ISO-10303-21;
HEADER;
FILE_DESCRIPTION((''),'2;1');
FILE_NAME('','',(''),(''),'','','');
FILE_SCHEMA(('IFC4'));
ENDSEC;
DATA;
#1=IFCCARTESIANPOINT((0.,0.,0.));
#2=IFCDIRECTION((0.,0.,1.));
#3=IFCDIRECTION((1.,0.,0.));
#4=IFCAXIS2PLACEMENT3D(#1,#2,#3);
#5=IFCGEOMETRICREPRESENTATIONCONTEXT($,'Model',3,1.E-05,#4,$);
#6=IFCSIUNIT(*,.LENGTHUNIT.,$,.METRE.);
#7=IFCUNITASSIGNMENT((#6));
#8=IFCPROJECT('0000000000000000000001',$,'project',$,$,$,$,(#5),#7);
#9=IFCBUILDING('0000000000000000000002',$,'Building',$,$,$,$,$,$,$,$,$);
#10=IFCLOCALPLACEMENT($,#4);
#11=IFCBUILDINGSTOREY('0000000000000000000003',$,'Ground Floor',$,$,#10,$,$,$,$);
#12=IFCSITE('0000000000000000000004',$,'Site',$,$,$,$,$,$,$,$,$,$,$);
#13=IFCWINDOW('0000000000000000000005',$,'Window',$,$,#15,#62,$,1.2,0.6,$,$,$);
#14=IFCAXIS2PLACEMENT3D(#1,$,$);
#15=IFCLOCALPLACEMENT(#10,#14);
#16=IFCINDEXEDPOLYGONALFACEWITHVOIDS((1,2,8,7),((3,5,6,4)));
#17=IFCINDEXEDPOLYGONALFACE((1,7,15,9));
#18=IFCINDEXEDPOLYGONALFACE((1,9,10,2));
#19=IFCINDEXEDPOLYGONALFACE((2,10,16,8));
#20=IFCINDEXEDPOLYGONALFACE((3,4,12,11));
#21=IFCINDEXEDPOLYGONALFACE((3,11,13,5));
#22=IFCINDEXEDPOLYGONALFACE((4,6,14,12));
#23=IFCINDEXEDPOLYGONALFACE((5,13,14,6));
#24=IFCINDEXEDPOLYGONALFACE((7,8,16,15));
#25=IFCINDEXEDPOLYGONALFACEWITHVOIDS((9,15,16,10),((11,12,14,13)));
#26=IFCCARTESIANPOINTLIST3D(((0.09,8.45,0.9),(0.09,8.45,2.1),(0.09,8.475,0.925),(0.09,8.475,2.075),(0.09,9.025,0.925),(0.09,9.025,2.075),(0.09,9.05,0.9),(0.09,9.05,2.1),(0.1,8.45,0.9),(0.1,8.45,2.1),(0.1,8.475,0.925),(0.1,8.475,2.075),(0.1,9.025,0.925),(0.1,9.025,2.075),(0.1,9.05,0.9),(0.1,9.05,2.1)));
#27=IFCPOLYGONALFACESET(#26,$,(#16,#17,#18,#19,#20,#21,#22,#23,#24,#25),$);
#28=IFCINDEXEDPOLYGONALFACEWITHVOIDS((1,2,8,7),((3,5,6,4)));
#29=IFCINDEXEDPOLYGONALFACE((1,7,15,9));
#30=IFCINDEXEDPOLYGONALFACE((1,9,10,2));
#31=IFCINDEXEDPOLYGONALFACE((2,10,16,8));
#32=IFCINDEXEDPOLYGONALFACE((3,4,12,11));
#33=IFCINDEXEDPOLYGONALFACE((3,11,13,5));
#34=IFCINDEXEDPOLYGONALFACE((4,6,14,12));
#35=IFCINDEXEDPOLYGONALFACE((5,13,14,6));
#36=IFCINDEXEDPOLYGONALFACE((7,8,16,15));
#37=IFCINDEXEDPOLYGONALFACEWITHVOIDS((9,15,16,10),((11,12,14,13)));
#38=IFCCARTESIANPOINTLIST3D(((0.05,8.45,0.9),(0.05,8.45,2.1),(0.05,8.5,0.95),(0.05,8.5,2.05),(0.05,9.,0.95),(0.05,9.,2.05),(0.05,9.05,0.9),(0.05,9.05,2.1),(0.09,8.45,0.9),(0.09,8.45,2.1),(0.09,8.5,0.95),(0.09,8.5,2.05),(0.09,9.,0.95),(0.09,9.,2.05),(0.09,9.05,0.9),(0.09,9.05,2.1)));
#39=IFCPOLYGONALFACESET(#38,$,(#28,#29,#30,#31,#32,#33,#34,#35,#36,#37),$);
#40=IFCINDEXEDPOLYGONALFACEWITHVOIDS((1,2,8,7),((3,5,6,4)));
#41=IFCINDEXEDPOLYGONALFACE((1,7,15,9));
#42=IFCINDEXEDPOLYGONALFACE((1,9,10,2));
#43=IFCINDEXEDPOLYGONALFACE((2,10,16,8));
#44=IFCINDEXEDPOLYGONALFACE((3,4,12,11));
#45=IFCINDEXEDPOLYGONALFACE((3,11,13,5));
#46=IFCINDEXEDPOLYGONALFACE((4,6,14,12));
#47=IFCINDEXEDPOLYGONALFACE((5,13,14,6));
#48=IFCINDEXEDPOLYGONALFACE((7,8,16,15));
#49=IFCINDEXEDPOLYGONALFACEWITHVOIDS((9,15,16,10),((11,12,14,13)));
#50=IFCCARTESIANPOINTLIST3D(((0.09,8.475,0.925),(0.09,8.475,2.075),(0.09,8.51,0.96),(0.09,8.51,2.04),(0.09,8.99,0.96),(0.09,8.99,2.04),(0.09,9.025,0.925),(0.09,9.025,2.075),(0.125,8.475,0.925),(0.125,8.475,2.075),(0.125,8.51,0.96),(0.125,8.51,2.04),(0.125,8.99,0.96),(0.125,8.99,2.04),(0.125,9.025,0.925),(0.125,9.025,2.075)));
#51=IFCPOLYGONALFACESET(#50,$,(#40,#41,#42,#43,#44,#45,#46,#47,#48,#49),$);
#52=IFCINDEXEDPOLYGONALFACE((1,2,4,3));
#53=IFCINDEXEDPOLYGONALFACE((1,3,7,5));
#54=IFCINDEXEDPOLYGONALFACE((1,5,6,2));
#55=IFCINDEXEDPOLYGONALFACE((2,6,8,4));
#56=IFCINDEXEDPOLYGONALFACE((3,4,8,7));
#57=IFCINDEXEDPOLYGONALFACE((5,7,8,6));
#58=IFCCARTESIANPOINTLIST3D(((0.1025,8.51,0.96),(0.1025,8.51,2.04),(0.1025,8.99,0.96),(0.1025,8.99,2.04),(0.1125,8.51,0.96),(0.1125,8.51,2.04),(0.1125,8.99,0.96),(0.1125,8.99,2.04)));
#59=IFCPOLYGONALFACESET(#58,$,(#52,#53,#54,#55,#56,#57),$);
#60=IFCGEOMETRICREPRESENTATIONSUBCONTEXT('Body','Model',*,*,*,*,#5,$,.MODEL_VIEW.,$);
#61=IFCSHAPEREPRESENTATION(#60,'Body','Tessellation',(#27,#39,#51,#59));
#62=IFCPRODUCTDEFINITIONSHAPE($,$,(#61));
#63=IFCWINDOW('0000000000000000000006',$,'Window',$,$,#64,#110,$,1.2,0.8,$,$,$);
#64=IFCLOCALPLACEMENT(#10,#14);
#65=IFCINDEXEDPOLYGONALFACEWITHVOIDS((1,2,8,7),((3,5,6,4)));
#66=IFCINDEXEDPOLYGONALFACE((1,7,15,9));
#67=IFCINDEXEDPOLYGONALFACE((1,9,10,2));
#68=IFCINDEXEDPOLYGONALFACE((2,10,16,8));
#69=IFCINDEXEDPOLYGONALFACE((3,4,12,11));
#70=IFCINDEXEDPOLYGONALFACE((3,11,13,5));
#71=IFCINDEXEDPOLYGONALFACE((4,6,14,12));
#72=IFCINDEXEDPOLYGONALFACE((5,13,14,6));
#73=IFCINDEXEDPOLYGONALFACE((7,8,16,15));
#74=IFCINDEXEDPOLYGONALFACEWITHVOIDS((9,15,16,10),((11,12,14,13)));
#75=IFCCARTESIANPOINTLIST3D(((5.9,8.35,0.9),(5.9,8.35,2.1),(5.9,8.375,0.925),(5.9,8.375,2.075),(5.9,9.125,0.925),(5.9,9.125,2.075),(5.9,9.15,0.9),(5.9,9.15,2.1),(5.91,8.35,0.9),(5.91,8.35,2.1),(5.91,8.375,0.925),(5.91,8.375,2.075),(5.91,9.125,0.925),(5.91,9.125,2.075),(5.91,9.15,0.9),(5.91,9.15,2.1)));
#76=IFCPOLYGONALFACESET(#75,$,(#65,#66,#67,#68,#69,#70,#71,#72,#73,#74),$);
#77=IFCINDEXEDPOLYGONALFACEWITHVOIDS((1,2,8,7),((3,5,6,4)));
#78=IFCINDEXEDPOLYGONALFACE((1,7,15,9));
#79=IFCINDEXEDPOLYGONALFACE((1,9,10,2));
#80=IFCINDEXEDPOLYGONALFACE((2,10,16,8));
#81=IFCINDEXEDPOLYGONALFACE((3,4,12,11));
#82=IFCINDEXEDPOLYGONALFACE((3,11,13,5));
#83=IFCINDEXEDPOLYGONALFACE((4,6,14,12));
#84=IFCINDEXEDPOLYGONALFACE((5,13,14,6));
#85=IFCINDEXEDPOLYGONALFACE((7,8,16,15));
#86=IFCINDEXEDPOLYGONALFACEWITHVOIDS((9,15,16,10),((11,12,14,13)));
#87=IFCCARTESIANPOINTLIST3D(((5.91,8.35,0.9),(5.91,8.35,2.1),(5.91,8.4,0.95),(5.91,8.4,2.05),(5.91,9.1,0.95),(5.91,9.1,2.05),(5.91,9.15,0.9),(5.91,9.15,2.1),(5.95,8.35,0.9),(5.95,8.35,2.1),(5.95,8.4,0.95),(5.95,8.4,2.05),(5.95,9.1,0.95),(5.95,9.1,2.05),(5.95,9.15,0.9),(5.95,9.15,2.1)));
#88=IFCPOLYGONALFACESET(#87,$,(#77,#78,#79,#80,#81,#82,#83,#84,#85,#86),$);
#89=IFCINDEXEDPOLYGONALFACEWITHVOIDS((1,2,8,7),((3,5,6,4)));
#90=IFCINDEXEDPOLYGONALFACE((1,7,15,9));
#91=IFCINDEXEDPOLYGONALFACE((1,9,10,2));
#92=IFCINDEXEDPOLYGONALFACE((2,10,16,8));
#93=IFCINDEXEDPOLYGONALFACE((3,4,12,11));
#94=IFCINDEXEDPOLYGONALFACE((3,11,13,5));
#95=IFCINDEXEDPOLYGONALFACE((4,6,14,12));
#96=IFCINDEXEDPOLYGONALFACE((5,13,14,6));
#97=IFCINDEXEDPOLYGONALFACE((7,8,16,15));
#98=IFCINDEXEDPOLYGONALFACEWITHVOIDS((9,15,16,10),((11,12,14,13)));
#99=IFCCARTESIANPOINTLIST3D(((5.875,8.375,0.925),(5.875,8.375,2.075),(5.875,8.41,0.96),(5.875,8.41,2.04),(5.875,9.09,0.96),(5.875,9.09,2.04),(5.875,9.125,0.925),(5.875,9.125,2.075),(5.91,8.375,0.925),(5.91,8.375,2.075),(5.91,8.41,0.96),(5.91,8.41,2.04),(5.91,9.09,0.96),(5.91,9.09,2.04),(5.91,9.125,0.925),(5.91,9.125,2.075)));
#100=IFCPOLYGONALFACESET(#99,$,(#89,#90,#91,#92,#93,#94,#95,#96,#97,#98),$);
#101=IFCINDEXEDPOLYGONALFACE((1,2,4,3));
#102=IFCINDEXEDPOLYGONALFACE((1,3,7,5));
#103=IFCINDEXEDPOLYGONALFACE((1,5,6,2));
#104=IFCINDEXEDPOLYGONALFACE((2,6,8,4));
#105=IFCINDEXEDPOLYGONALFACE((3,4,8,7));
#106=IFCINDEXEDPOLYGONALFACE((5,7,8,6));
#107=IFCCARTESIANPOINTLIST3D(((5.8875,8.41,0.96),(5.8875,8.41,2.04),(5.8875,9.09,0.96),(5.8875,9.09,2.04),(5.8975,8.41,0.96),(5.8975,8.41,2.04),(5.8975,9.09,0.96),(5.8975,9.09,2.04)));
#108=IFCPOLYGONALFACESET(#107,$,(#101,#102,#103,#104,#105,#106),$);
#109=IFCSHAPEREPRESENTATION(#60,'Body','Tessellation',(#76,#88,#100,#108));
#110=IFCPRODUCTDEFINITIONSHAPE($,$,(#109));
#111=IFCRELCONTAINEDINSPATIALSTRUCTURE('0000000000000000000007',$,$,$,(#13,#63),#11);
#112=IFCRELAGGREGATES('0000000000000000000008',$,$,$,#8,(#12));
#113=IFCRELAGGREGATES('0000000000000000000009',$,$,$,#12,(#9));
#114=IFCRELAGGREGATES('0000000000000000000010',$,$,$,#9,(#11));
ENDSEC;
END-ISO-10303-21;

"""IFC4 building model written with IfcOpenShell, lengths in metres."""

from ifc_helpers import new_model, si_unit, frame, origin_with_axes, place, context, subcontext, project, spatial, line, indexed_curve, outline, extrude, element, save


model = new_model("IFC4")

# Units and contexts
model_context = context("Model", 3, precision=1e-05, world=origin_with_axes())
body_context = subcontext(model_context, "Body", "Model", "MODEL_VIEW")
ifc_project = project(units=[si_unit("LENGTHUNIT", "METRE")], contexts=[model_context])

# Site, building, storey
site = spatial("IfcSite", under=ifc_project, Name="Site")
building = spatial("IfcBuilding", under=site, Name="Building")
storey_placement = place(None, origin_with_axes())
storey = spatial("IfcBuildingStorey", under=building, at=storey_placement, Name="Ground Floor")

# Windows
window_1_placement = place(storey_placement, frame((0.0, 9.05, 0.9), z_axis=(0.0, 0.0, 1.0), x_axis=(0.0, -1.0, 0.0)))
element("IfcWindow", 1, at=window_1_placement, inside=storey, Name="Window", OverallHeight=1.2, OverallWidth=0.6, context=body_context, shape_type="SweptSolid", body=[
    extrude(outline(indexed_curve([(0.0, 0.0), (0.6, 0.0), (0.6, 1.2), (0.0, 1.2)], segments=[line(1, 2, 3, 4, 1)]), holes=[indexed_curve([(0.025, 0.025), (0.575, 0.025), (0.575, 1.175), (0.025, 1.175)], segments=[line(1, 2, 3, 4, 1)])]), frame((0.0, 0.09, 0.0), z_axis=(0.0, -1.0, 0.0), x_axis=(1.0, 0.0, 0.0)), (0.0, 0.0, -1.0), 0.01),
    extrude(outline(indexed_curve([(0.0, 0.0), (0.6, 0.0), (0.6, 1.2), (0.0, 1.2)], segments=[line(1, 2, 3, 4, 1)]), holes=[indexed_curve([(0.05, 0.05), (0.55, 0.05), (0.55, 1.15), (0.05, 1.15)], segments=[line(1, 2, 3, 4, 1)])]), frame((0.0, 0.05, 0.0), z_axis=(0.0, -1.0, 0.0), x_axis=(1.0, 0.0, 0.0)), (0.0, 0.0, -1.0), 0.04),
    extrude(outline(indexed_curve([(0.0, 0.0), (0.55, 0.0), (0.55, 1.15), (0.0, 1.15)], segments=[line(1, 2, 3, 4, 1)]), holes=[indexed_curve([(0.035, 0.035), (0.515, 0.035), (0.515, 1.115), (0.035, 1.115)], segments=[line(1, 2, 3, 4, 1)])]), frame((0.025, 0.09, 0.025), z_axis=(0.0, -1.0, 0.0), x_axis=(1.0, 0.0, 0.0)), (0.0, 0.0, -1.0), 0.035),
    extrude(outline(indexed_curve([(0.035, 0.035), (0.515, 0.035), (0.515, 1.115), (0.035, 1.115)], segments=[line(1, 2, 3, 4, 1)])), frame((0.025, 0.1025, 0.025), z_axis=(0.0, -1.0, 0.0), x_axis=(1.0, 0.0, 0.0)), (0.0, 0.0, -1.0), 0.01),
])
window_2_placement = place(storey_placement, frame((6.0, 8.35, 0.9), z_axis=(0.0, 0.0, 1.0), x_axis=(0.0, 1.0, 0.0)))
element("IfcWindow", 2, at=window_2_placement, inside=storey, Name="Window", OverallHeight=1.2, OverallWidth=0.8, context=body_context, shape_type="SweptSolid", body=[
    extrude(outline(indexed_curve([(0.0, 0.0), (0.8, 0.0), (0.8, 1.2), (0.0, 1.2)], segments=[line(1, 2, 3, 4, 1)]), holes=[indexed_curve([(0.025, 0.025), (0.775, 0.025), (0.775, 1.175), (0.025, 1.175)], segments=[line(1, 2, 3, 4, 1)])]), frame((0.0, 0.09, 0.0), z_axis=(0.0, -1.0, 0.0), x_axis=(1.0, 0.0, 0.0)), (0.0, 0.0, -1.0), 0.01),
    extrude(outline(indexed_curve([(0.0, 0.0), (0.8, 0.0), (0.8, 1.2), (0.0, 1.2)], segments=[line(1, 2, 3, 4, 1)]), holes=[indexed_curve([(0.05, 0.05), (0.75, 0.05), (0.75, 1.15), (0.05, 1.15)], segments=[line(1, 2, 3, 4, 1)])]), frame((0.0, 0.05, 0.0), z_axis=(0.0, -1.0, 0.0), x_axis=(1.0, 0.0, 0.0)), (0.0, 0.0, -1.0), 0.04),
    extrude(outline(indexed_curve([(0.0, 0.0), (0.75, 0.0), (0.75, 1.15), (0.0, 1.15)], segments=[line(1, 2, 3, 4, 1)]), holes=[indexed_curve([(0.035, 0.035), (0.715, 0.035), (0.715, 1.115), (0.035, 1.115)], segments=[line(1, 2, 3, 4, 1)])]), frame((0.025, 0.09, 0.025), z_axis=(0.0, -1.0, 0.0), x_axis=(1.0, 0.0, 0.0)), (0.0, 0.0, -1.0), 0.035),
    extrude(outline(indexed_curve([(0.035, 0.035), (0.715, 0.035), (0.715, 1.115), (0.035, 1.115)], segments=[line(1, 2, 3, 4, 1)])), frame((0.025, 0.1025, 0.025), z_axis=(0.0, -1.0, 0.0), x_axis=(1.0, 0.0, 0.0)), (0.0, 0.0, -1.0), 0.01),
])

save(model, "model.ifc")
